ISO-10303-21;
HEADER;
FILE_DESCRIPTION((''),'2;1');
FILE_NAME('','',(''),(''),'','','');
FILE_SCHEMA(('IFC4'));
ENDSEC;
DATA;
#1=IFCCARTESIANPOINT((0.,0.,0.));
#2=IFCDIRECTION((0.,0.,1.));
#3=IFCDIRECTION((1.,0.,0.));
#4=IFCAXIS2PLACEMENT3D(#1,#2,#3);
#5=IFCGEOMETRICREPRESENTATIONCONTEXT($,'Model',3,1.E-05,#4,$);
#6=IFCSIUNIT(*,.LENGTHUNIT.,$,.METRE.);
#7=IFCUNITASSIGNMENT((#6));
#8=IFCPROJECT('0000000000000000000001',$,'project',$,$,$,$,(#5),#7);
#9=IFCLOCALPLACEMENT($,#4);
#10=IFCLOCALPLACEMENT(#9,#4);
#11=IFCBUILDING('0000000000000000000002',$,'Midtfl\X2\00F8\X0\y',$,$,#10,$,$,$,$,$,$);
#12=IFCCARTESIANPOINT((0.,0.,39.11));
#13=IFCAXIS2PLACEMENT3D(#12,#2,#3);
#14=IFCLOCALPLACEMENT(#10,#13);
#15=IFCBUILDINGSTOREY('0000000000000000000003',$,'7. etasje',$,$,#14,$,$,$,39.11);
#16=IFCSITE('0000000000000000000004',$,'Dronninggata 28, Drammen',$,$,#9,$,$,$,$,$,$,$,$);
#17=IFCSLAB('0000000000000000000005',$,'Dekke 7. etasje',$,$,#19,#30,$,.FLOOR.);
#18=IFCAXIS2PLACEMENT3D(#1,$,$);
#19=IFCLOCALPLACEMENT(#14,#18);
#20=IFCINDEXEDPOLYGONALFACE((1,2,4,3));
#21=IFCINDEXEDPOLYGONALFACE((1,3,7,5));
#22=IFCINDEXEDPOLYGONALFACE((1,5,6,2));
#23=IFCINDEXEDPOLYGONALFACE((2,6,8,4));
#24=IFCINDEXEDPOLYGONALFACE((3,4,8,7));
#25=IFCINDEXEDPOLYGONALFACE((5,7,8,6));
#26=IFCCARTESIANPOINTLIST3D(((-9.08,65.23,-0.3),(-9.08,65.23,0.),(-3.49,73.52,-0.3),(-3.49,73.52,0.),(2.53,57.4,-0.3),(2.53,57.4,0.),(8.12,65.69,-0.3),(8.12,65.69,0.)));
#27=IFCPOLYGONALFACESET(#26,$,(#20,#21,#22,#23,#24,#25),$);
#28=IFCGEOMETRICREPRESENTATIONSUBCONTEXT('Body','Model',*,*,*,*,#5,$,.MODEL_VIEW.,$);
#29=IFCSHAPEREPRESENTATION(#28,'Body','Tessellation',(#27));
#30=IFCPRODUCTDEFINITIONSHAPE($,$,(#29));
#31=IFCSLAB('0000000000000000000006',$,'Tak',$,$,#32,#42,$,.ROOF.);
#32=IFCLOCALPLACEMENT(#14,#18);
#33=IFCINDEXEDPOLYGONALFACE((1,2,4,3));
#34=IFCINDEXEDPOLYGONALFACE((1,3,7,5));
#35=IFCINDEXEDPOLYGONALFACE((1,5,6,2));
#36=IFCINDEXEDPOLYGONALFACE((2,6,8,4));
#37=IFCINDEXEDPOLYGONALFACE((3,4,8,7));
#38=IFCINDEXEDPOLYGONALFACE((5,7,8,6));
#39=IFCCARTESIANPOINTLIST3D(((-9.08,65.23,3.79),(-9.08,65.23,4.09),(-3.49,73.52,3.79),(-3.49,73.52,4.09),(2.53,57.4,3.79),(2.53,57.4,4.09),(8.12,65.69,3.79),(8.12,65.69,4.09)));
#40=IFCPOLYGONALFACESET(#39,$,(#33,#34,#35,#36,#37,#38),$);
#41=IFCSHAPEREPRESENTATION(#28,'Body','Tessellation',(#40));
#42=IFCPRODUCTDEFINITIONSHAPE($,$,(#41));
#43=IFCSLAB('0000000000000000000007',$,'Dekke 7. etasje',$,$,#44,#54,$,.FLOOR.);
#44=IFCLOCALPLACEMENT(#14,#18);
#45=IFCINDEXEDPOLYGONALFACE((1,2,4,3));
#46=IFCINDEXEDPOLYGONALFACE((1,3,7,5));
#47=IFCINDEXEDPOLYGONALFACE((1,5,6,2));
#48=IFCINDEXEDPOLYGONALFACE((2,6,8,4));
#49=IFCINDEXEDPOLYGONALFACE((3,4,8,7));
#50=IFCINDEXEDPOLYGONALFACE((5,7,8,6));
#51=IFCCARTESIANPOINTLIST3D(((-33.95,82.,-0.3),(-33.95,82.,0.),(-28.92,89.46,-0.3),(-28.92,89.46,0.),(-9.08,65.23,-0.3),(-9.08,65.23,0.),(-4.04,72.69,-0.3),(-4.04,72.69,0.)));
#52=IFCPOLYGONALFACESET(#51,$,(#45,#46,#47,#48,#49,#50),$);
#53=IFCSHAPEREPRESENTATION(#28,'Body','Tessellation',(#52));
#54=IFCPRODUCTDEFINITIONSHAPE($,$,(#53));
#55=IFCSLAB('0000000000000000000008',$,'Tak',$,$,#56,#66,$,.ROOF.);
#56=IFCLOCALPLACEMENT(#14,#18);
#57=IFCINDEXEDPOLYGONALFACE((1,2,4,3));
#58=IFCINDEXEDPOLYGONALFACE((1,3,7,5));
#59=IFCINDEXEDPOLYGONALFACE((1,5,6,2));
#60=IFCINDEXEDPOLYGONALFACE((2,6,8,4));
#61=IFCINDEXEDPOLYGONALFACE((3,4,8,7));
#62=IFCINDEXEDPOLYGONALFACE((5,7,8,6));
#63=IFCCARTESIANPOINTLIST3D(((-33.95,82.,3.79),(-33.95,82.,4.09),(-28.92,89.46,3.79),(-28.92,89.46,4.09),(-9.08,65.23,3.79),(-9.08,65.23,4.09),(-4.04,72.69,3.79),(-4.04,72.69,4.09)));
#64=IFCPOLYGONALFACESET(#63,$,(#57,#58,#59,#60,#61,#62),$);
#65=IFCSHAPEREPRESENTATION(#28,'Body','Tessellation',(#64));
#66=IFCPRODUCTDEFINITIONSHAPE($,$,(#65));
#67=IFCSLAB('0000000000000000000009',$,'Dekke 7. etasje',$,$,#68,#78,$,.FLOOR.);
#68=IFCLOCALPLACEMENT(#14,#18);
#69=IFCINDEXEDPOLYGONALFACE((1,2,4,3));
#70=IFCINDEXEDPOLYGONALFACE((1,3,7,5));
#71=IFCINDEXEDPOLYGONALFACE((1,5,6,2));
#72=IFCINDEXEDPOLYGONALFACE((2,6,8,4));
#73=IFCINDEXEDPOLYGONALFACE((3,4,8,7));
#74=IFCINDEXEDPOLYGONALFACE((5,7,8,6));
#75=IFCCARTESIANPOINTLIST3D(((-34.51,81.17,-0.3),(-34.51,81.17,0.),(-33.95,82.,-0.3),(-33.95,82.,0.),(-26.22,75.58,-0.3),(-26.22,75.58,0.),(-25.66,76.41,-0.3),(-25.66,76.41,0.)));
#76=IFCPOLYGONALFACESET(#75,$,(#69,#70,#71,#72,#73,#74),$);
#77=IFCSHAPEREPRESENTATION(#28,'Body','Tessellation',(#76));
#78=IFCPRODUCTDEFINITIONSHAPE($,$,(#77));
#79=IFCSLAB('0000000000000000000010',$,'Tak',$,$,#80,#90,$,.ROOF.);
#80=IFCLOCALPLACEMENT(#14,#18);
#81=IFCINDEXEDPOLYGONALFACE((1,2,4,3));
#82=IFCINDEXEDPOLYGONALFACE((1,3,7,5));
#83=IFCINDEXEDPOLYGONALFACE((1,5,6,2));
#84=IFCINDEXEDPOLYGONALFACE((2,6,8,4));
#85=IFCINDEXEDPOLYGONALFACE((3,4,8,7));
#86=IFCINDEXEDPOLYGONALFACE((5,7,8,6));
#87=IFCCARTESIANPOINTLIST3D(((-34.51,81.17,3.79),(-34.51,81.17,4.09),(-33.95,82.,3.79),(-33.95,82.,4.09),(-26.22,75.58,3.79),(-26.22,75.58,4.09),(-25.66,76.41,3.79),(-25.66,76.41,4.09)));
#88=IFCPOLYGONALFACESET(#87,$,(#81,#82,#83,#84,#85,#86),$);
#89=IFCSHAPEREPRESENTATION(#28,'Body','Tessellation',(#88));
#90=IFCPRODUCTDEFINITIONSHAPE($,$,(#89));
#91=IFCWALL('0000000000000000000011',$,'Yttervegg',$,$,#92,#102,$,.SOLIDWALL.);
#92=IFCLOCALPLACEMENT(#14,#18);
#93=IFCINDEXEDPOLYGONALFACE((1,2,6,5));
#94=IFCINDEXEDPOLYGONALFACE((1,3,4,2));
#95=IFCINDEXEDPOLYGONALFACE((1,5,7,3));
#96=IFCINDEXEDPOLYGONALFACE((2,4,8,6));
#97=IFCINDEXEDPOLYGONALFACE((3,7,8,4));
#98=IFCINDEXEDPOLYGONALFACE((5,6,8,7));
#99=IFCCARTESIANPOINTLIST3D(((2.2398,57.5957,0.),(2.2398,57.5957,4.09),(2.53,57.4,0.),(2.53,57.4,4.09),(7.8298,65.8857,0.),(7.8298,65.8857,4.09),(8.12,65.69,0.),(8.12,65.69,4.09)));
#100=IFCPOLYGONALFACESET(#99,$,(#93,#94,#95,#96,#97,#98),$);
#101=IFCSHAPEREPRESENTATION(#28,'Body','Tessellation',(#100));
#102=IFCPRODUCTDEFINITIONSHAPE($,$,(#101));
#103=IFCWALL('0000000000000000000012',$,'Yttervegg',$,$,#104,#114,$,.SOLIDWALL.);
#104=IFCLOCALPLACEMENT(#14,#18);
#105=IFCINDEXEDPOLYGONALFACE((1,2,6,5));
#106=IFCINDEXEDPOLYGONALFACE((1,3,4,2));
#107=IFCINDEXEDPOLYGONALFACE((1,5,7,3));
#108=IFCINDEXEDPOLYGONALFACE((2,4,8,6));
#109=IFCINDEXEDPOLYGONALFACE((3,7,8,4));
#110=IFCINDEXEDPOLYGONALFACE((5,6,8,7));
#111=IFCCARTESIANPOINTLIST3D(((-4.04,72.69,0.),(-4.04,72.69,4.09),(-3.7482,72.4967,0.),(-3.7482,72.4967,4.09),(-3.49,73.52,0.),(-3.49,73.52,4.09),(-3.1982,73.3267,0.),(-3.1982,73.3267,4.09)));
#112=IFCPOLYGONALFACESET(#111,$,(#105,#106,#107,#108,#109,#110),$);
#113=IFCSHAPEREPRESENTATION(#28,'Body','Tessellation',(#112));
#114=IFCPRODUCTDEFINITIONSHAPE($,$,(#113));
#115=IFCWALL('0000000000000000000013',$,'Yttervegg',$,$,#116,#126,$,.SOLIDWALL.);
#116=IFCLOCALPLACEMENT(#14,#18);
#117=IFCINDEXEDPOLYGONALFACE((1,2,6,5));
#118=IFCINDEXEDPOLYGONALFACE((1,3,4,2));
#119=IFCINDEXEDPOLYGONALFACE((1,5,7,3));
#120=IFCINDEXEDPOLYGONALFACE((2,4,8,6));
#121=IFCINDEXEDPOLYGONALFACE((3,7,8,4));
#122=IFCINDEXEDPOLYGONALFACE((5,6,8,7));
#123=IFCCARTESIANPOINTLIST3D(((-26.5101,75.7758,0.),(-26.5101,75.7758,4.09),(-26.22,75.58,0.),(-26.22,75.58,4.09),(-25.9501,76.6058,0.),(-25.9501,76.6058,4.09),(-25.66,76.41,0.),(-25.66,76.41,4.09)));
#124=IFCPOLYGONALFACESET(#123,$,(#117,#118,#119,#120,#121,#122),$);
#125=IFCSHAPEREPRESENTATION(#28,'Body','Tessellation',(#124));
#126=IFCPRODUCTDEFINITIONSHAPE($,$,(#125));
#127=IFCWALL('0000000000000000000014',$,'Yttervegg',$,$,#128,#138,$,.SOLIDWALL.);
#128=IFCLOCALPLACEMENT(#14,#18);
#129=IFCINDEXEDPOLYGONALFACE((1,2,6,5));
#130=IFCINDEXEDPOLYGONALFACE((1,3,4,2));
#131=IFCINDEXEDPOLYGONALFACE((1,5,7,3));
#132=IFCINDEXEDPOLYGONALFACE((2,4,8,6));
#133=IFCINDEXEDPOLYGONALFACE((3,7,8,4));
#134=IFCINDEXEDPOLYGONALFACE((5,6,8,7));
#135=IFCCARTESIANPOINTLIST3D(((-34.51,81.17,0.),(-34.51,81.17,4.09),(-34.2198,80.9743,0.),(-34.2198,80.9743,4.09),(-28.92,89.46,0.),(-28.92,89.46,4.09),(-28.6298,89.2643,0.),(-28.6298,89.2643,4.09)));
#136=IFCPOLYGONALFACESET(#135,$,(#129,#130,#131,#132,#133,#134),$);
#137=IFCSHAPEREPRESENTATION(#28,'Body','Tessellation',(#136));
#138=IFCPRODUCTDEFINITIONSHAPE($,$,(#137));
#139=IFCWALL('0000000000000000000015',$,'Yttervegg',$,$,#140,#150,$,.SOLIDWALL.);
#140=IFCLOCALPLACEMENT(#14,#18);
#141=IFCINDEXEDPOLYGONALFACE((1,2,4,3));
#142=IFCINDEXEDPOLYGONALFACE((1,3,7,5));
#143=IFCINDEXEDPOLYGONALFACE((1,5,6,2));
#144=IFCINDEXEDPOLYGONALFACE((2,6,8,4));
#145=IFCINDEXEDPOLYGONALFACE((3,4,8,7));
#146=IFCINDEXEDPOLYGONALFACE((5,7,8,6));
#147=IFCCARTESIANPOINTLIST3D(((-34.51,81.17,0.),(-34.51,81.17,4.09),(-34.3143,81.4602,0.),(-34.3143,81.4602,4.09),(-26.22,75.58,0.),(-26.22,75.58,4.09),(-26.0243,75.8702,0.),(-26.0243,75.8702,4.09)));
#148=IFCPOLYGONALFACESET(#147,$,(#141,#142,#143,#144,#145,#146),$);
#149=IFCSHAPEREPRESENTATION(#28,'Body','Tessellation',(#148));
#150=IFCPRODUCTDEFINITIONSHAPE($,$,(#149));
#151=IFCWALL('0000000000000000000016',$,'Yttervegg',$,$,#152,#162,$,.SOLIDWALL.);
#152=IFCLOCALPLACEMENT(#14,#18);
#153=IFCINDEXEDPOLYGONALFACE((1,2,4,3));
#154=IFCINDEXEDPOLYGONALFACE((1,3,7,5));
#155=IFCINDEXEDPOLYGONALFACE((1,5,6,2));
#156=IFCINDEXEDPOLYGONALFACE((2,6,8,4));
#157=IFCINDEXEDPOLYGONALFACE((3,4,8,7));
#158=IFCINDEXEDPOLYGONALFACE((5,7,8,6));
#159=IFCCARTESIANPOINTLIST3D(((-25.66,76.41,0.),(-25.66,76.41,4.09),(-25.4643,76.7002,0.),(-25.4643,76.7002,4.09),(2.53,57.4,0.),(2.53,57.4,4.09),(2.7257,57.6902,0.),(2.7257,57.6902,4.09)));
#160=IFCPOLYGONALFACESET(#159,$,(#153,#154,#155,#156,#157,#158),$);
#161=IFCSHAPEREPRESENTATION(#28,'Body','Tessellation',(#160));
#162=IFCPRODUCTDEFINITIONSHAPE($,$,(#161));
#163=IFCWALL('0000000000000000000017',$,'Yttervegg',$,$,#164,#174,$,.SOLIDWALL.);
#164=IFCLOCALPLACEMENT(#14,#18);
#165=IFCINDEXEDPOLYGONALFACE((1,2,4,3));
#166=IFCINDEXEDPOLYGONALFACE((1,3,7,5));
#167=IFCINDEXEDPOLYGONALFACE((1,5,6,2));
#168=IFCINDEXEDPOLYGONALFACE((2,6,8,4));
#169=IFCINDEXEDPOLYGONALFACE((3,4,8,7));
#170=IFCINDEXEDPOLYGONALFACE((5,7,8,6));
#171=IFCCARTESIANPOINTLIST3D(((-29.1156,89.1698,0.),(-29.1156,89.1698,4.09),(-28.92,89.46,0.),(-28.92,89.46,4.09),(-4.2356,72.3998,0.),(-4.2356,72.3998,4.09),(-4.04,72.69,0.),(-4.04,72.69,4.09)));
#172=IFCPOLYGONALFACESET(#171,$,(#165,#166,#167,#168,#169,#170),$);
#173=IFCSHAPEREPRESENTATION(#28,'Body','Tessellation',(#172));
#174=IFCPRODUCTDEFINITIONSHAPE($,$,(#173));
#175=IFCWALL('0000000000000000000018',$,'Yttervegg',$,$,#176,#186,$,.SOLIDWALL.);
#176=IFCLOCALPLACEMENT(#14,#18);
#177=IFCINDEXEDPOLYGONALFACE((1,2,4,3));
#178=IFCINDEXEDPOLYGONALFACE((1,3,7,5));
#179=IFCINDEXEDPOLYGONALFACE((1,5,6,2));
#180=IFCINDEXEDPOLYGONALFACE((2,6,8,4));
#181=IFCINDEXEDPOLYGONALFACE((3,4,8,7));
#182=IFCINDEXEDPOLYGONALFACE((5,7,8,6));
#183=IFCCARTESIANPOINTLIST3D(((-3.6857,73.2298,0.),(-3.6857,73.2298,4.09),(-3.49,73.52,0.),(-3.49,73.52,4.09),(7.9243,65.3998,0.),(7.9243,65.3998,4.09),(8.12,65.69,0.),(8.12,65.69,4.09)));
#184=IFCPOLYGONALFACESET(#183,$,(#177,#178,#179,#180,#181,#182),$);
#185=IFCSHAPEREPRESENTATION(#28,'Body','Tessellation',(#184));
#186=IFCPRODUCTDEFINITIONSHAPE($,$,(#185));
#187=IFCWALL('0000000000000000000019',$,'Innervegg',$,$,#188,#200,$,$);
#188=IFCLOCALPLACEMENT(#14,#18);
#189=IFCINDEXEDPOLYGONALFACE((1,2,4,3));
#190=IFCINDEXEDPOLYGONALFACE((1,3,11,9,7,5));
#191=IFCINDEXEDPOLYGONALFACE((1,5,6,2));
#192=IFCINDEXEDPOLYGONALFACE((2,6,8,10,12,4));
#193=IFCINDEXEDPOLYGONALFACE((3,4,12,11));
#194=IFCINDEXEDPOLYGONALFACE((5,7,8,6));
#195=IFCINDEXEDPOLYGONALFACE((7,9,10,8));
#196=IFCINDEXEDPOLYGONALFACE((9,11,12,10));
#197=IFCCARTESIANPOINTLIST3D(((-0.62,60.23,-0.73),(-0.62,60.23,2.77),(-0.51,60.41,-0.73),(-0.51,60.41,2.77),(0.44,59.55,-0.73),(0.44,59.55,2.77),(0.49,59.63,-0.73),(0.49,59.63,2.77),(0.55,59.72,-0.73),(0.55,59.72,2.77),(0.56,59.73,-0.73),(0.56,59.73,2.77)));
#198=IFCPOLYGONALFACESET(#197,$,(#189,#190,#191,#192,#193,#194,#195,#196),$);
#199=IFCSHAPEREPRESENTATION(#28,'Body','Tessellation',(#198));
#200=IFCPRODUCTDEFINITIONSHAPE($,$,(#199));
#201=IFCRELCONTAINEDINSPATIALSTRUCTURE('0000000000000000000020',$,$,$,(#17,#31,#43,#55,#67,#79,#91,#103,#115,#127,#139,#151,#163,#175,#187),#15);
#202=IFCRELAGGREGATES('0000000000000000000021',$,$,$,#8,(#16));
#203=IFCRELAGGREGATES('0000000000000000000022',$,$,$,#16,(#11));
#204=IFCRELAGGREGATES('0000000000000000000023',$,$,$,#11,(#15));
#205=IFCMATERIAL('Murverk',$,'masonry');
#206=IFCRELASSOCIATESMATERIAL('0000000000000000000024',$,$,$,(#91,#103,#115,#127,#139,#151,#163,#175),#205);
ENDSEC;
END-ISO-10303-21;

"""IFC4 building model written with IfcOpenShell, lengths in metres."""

from ifc_helpers import new_model, si_unit, frame, origin_with_axes, place, context, subcontext, project, spatial, polyline, outline, extrude, material, element, save


model = new_model("IFC4")

# Units and contexts
model_context = context("Model", 3, precision=1e-05, world=origin_with_axes())
body_context = subcontext(model_context, "Body", "Model", "MODEL_VIEW")
ifc_project = project(units=[si_unit("LENGTHUNIT", "METRE")], contexts=[model_context])

# Site, building, storey
site_placement = place(None, origin_with_axes())
site = spatial("IfcSite", under=ifc_project, at=site_placement, Name="Dronninggata 28, Drammen")
building_placement = place(site_placement, origin_with_axes())
building = spatial("IfcBuilding", under=site, at=building_placement, Name="Midtfløy")
storey_placement = place(building_placement, frame((0.0, 0.0, 39.11), z_axis=(0.0, 0.0, 1.0), x_axis=(1.0, 0.0, 0.0)))
storey = spatial("IfcBuildingStorey", under=building, at=storey_placement, Name="7. etasje", Elevation=39.11)

# Slabs
slab_1_placement = place(storey_placement, frame((0.0, 0.0, -39.11), z_axis=(0.0, 0.0, 1.0), x_axis=(1.0, 0.0, 0.0)))
element("IfcSlab", 1, at=slab_1_placement, inside=storey, Name="Dekke 7. etasje", PredefinedType="FLOOR", context=body_context, shape_type="SweptSolid", body=[
    extrude(outline(polyline([(2.53, 57.4), (8.12, 65.69), (-3.49, 73.52), (-9.08, 65.23), (2.53, 57.4)])), frame((0.0, 0.0, 38.81)), (0.0, 0.0, 1.0), 0.3),
])
slab_2_placement = place(storey_placement, frame((0.0, 0.0, -39.11), z_axis=(0.0, 0.0, 1.0), x_axis=(1.0, 0.0, 0.0)))
element("IfcSlab", 2, at=slab_2_placement, inside=storey, Name="Tak", PredefinedType="ROOF", context=body_context, shape_type="SweptSolid", body=[
    extrude(outline(polyline([(2.53, 57.4), (8.12, 65.69), (-3.49, 73.52), (-9.08, 65.23), (2.53, 57.4)])), frame((0.0, 0.0, 42.9)), (0.0, 0.0, 1.0), 0.3),
])
slab_3_placement = place(storey_placement, frame((0.0, 0.0, -39.11), z_axis=(0.0, 0.0, 1.0), x_axis=(1.0, 0.0, 0.0)))
element("IfcSlab", 3, at=slab_3_placement, inside=storey, Name="Dekke 7. etasje", PredefinedType="FLOOR", context=body_context, shape_type="SweptSolid", body=[
    extrude(outline(polyline([(-9.08, 65.23), (-4.04, 72.69), (-28.92, 89.46), (-33.95, 82.0), (-9.08, 65.23)])), frame((0.0, 0.0, 38.81)), (0.0, 0.0, 1.0), 0.3),
])
slab_4_placement = place(storey_placement, frame((0.0, 0.0, -39.11), z_axis=(0.0, 0.0, 1.0), x_axis=(1.0, 0.0, 0.0)))
element("IfcSlab", 4, at=slab_4_placement, inside=storey, Name="Tak", PredefinedType="ROOF", context=body_context, shape_type="SweptSolid", body=[
    extrude(outline(polyline([(-9.08, 65.23), (-4.04, 72.69), (-28.92, 89.46), (-33.95, 82.0), (-9.08, 65.23)])), frame((0.0, 0.0, 42.9)), (0.0, 0.0, 1.0), 0.3),
])
slab_5_placement = place(storey_placement, frame((0.0, 0.0, -39.11), z_axis=(0.0, 0.0, 1.0), x_axis=(1.0, 0.0, 0.0)))
element("IfcSlab", 5, at=slab_5_placement, inside=storey, Name="Dekke 7. etasje", PredefinedType="FLOOR", context=body_context, shape_type="SweptSolid", body=[
    extrude(outline(polyline([(-26.22, 75.58), (-25.66, 76.41), (-33.95, 82.0), (-34.51, 81.17), (-26.22, 75.58)])), frame((0.0, 0.0, 38.81)), (0.0, 0.0, 1.0), 0.3),
])
slab_6_placement = place(storey_placement, frame((0.0, 0.0, -39.11), z_axis=(0.0, 0.0, 1.0), x_axis=(1.0, 0.0, 0.0)))
element("IfcSlab", 6, at=slab_6_placement, inside=storey, Name="Tak", PredefinedType="ROOF", context=body_context, shape_type="SweptSolid", body=[
    extrude(outline(polyline([(-26.22, 75.58), (-25.66, 76.41), (-33.95, 82.0), (-34.51, 81.17), (-26.22, 75.58)])), frame((0.0, 0.0, 42.9)), (0.0, 0.0, 1.0), 0.3),
])

# Walls
ifc_material = material(Name="Murverk", Category="masonry")
wall_1_placement = place(storey_placement, frame((0.0, 0.0, -39.11), z_axis=(0.0, 0.0, 1.0), x_axis=(1.0, 0.0, 0.0)))
element("IfcWall", 7, at=wall_1_placement, inside=storey, material=ifc_material, Name="Yttervegg", PredefinedType="SOLIDWALL", context=body_context, shape_type="SweptSolid", body=[
    extrude(outline(polyline([(2.53, 57.4), (8.12, 65.69), (7.8298, 65.8857), (2.2398, 57.5957), (2.53, 57.4)])), frame((0.0, 0.0, 39.11)), (0.0, 0.0, 1.0), 4.09),
])
wall_2_placement = place(storey_placement, frame((0.0, 0.0, -39.11), z_axis=(0.0, 0.0, 1.0), x_axis=(1.0, 0.0, 0.0)))
element("IfcWall", 8, at=wall_2_placement, inside=storey, material=ifc_material, Name="Yttervegg", PredefinedType="SOLIDWALL", context=body_context, shape_type="SweptSolid", body=[
    extrude(outline(polyline([(-3.49, 73.52), (-4.04, 72.69), (-3.7482, 72.4967), (-3.1982, 73.3267), (-3.49, 73.52)])), frame((0.0, 0.0, 39.11)), (0.0, 0.0, 1.0), 4.09),
])
wall_3_placement = place(storey_placement, frame((0.0, 0.0, -39.11), z_axis=(0.0, 0.0, 1.0), x_axis=(1.0, 0.0, 0.0)))
element("IfcWall", 9, at=wall_3_placement, inside=storey, material=ifc_material, Name="Yttervegg", PredefinedType="SOLIDWALL", context=body_context, shape_type="SweptSolid", body=[
    extrude(outline(polyline([(-26.22, 75.58), (-25.66, 76.41), (-25.9501, 76.6058), (-26.5101, 75.7758), (-26.22, 75.58)])), frame((0.0, 0.0, 39.11)), (0.0, 0.0, 1.0), 4.09),
])
wall_4_placement = place(storey_placement, frame((0.0, 0.0, -39.11), z_axis=(0.0, 0.0, 1.0), x_axis=(1.0, 0.0, 0.0)))
element("IfcWall", 10, at=wall_4_placement, inside=storey, material=ifc_material, Name="Yttervegg", PredefinedType="SOLIDWALL", context=body_context, shape_type="SweptSolid", body=[
    extrude(outline(polyline([(-28.92, 89.46), (-34.51, 81.17), (-34.2198, 80.9743), (-28.6298, 89.2643), (-28.92, 89.46)])), frame((0.0, 0.0, 39.11)), (0.0, 0.0, 1.0), 4.09),
])
wall_5_placement = place(storey_placement, frame((0.0, 0.0, -39.11), z_axis=(0.0, 0.0, 1.0), x_axis=(1.0, 0.0, 0.0)))
element("IfcWall", 11, at=wall_5_placement, inside=storey, material=ifc_material, Name="Yttervegg", PredefinedType="SOLIDWALL", context=body_context, shape_type="SweptSolid", body=[
    extrude(outline(polyline([(-26.22, 75.58), (-34.51, 81.17), (-34.3143, 81.4602), (-26.0243, 75.8702), (-26.22, 75.58)])), frame((0.0, 0.0, 39.11)), (0.0, 0.0, 1.0), 4.09),
])
wall_6_placement = place(storey_placement, frame((0.0, 0.0, -39.11), z_axis=(0.0, 0.0, 1.0), x_axis=(1.0, 0.0, 0.0)))
element("IfcWall", 12, at=wall_6_placement, inside=storey, material=ifc_material, Name="Yttervegg", PredefinedType="SOLIDWALL", context=body_context, shape_type="SweptSolid", body=[
    extrude(outline(polyline([(2.53, 57.4), (-25.66, 76.41), (-25.4643, 76.7002), (2.7257, 57.6902), (2.53, 57.4)])), frame((0.0, 0.0, 39.11)), (0.0, 0.0, 1.0), 4.09),
])
wall_7_placement = place(storey_placement, frame((0.0, 0.0, -39.11), z_axis=(0.0, 0.0, 1.0), x_axis=(1.0, 0.0, 0.0)))
element("IfcWall", 13, at=wall_7_placement, inside=storey, material=ifc_material, Name="Yttervegg", PredefinedType="SOLIDWALL", context=body_context, shape_type="SweptSolid", body=[
    extrude(outline(polyline([(-28.92, 89.46), (-4.04, 72.69), (-4.2356, 72.3998), (-29.1156, 89.1698), (-28.92, 89.46)])), frame((0.0, 0.0, 39.11)), (0.0, 0.0, 1.0), 4.09),
])
wall_8_placement = place(storey_placement, frame((0.0, 0.0, -39.11), z_axis=(0.0, 0.0, 1.0), x_axis=(1.0, 0.0, 0.0)))
element("IfcWall", 14, at=wall_8_placement, inside=storey, material=ifc_material, Name="Yttervegg", PredefinedType="SOLIDWALL", context=body_context, shape_type="SweptSolid", body=[
    extrude(outline(polyline([(-3.49, 73.52), (8.12, 65.69), (7.9243, 65.3998), (-3.6857, 73.2298), (-3.49, 73.52)])), frame((0.0, 0.0, 39.11)), (0.0, 0.0, 1.0), 4.09),
])
wall_9_placement = place(storey_placement, frame((0.0, 0.0, -39.11), z_axis=(0.0, 0.0, 1.0), x_axis=(1.0, 0.0, 0.0)))
element("IfcWall", 15, at=wall_9_placement, inside=storey, Name="Innervegg", context=body_context, shape_type="SweptSolid", body=[
    extrude(outline(polyline([(-0.51, 60.41), (-0.62, 60.23), (0.44, 59.55), (0.49, 59.63), (0.55, 59.72), (0.56, 59.73), (-0.51, 60.41)])), frame((0.0, 0.0, 38.38)), (0.0, 0.0, 1.0), 3.5),
])

save(model, "model.ifc")
